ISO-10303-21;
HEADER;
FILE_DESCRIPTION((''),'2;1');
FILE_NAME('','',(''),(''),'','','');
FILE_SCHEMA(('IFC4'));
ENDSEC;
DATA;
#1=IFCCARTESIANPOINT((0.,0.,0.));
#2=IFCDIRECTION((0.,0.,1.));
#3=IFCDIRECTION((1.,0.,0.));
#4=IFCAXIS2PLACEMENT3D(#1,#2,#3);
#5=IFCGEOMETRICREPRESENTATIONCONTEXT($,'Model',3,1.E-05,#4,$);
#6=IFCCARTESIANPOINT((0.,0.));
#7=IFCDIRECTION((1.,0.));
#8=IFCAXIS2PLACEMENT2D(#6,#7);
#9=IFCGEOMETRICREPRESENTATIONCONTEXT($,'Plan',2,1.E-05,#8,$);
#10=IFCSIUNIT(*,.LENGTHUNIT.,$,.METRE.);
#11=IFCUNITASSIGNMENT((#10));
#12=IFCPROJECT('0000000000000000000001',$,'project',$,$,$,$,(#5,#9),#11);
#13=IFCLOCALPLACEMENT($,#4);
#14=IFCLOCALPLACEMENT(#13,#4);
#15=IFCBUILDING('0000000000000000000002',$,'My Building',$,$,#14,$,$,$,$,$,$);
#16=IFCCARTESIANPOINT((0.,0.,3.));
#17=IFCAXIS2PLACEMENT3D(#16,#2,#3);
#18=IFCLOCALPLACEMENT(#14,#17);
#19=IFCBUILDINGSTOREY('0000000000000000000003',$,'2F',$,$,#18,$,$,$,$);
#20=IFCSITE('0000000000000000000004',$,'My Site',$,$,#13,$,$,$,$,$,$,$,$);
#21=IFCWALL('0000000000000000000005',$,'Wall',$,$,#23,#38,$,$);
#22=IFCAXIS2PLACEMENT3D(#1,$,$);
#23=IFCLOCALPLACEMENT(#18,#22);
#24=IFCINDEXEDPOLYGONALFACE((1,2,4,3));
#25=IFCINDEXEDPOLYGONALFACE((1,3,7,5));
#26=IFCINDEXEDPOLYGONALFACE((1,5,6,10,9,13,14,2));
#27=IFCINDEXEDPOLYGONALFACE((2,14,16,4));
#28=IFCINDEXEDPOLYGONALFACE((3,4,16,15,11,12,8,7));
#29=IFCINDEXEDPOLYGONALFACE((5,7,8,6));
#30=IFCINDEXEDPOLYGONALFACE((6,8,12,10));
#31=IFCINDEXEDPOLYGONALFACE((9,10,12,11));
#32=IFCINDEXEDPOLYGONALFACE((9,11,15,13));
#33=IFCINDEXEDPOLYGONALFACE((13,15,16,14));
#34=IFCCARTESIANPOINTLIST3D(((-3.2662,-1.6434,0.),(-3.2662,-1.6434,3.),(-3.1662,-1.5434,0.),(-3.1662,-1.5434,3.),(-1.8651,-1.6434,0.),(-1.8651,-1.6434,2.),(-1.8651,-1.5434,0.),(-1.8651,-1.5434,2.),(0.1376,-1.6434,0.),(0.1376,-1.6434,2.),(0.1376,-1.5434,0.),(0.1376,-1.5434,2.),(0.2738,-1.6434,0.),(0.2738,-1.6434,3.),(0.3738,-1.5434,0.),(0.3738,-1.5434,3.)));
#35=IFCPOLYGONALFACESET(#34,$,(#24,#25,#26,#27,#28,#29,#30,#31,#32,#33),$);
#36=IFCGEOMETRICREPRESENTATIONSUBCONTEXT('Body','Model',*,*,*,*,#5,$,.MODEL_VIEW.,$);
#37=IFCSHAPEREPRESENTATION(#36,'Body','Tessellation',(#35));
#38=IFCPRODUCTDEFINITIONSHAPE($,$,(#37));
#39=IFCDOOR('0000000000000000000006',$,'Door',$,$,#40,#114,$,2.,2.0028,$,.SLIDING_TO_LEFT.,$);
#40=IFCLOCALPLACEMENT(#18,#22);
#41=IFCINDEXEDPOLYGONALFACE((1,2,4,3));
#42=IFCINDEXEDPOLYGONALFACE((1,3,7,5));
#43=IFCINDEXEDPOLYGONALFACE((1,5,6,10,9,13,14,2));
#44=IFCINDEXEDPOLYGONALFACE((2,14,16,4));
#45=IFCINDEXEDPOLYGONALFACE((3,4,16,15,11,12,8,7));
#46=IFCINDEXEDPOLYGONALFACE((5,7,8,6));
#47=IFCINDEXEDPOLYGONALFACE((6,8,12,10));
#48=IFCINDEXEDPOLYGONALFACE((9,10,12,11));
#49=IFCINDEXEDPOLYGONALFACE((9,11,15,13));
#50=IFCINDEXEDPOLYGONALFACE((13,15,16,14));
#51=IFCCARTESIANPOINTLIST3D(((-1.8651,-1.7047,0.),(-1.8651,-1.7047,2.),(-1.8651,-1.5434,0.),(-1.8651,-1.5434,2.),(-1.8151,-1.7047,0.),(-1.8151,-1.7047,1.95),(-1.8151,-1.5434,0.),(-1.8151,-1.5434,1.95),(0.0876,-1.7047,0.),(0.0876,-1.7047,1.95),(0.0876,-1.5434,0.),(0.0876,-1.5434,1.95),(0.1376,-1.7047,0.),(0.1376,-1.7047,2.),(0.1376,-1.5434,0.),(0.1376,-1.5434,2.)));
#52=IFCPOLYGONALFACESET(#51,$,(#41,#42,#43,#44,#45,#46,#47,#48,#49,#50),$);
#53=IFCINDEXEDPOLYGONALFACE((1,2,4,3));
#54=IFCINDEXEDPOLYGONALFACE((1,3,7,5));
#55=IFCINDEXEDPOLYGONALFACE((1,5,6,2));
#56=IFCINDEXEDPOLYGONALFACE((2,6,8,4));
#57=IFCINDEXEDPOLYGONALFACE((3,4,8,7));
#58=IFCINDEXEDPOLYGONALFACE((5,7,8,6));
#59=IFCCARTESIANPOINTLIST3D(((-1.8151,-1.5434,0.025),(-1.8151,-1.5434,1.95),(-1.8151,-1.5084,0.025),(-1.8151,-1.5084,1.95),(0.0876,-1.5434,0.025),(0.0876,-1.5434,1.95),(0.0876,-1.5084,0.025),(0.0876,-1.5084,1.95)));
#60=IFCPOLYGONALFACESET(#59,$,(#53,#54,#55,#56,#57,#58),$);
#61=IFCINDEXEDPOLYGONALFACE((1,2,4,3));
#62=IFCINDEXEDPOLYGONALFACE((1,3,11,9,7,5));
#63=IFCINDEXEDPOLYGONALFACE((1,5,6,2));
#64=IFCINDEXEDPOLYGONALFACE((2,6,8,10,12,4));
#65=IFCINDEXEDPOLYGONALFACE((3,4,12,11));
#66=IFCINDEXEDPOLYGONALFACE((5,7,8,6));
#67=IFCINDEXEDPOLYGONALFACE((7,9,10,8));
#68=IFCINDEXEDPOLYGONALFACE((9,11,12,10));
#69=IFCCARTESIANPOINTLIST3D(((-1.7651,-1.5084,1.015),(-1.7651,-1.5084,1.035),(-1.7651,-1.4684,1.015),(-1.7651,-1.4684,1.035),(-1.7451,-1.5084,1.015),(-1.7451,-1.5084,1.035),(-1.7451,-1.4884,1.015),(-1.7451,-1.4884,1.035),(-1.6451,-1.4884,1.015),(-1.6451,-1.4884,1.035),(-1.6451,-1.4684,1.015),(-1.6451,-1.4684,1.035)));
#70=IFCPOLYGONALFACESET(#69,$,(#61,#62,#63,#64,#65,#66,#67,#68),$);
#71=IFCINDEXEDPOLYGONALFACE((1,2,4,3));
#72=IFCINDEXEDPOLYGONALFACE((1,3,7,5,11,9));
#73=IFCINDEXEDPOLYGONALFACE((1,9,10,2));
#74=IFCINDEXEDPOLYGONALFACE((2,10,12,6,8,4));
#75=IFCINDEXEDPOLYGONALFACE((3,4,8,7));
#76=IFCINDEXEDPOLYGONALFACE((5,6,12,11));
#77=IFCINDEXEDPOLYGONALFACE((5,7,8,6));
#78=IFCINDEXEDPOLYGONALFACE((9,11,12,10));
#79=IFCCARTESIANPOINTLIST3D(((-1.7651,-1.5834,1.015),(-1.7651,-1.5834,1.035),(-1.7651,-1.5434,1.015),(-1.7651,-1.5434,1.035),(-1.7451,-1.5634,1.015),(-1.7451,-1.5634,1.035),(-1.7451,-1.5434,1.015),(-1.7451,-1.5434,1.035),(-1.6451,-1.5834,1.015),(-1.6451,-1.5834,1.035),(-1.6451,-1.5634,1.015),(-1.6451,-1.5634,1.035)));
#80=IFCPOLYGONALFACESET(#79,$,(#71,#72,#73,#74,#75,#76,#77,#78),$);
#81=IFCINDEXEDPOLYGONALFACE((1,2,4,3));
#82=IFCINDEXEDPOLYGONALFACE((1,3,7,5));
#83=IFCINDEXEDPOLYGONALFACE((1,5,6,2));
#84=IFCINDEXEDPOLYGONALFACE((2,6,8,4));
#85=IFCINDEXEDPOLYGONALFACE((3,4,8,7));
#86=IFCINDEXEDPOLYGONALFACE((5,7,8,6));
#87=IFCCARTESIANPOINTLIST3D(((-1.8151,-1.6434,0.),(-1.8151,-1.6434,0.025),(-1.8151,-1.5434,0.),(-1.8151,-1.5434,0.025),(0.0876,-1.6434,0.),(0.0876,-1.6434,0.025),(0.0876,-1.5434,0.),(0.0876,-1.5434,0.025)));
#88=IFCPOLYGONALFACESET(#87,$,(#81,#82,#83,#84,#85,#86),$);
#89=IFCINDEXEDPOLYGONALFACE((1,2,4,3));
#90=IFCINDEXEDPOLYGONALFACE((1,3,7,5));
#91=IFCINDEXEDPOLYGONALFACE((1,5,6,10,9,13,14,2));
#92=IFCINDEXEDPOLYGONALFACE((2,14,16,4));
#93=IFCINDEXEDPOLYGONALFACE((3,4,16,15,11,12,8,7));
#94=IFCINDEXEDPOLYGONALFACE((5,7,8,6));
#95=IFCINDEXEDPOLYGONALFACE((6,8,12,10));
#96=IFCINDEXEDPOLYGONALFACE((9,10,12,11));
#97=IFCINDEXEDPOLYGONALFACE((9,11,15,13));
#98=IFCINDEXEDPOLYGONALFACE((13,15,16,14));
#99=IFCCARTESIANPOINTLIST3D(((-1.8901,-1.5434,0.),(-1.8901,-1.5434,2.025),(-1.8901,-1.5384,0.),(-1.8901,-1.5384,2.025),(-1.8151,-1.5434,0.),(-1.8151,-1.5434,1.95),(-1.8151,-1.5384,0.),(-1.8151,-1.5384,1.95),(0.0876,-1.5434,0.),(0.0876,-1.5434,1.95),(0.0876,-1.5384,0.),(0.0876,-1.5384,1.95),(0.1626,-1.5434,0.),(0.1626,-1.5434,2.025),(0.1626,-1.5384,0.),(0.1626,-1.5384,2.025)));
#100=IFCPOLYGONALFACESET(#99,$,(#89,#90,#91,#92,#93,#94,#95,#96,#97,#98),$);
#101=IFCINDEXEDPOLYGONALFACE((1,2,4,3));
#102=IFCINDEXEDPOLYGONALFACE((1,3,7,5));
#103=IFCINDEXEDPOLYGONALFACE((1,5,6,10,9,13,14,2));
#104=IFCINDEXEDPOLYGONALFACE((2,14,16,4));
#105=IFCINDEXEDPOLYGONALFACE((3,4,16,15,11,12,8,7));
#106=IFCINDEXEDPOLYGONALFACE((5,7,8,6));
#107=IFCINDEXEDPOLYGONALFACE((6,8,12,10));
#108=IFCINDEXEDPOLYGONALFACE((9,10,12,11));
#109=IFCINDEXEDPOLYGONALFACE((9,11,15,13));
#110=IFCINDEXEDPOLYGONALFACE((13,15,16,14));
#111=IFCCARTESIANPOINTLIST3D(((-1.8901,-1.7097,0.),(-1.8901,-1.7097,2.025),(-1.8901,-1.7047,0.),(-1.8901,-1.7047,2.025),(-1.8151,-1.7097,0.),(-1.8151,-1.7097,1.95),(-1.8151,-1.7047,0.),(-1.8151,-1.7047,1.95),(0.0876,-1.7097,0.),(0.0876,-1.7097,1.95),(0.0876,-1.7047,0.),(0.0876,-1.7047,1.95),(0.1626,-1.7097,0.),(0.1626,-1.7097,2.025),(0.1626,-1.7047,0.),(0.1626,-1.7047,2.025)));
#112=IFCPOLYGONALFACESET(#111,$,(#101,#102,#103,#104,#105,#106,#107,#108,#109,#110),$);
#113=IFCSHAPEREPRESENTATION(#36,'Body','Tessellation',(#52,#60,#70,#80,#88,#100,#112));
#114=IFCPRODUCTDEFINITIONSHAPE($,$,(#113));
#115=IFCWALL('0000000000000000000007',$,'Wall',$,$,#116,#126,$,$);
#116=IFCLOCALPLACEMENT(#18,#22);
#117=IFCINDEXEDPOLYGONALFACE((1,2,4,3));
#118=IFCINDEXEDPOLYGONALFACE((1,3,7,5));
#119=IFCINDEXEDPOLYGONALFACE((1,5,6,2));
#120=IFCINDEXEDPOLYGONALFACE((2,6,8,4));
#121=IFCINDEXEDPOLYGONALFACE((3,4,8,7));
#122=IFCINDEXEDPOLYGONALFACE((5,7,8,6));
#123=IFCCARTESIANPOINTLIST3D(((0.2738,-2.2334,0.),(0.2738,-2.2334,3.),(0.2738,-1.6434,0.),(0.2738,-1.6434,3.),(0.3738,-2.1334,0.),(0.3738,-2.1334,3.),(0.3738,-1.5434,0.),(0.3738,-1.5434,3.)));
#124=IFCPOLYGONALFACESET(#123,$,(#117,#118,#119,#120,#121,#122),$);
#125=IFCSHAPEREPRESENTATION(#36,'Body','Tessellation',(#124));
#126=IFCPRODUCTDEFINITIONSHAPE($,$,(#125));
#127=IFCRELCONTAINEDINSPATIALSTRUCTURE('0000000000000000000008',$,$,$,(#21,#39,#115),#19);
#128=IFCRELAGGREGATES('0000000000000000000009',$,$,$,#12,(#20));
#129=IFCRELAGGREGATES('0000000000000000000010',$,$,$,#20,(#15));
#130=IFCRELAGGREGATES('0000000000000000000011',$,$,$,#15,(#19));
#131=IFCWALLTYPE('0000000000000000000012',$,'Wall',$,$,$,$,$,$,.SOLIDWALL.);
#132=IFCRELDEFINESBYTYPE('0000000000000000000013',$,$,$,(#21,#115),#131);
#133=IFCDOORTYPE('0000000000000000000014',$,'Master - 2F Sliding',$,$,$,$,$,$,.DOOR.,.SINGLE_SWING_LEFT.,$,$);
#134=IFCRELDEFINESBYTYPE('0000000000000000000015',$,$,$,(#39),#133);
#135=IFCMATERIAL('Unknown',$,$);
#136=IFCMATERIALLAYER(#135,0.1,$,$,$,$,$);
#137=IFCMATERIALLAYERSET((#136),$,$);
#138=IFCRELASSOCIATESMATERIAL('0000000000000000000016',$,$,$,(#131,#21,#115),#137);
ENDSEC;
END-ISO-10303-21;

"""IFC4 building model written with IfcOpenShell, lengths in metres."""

from ifc_helpers import new_model, entity, si_unit, frame, origin_with_axes, origin_2d_with_axis, place, context, subcontext, project, spatial, line, indexed_curve, outline, extrude, shape, source, transform, mapped, material, layer, layer_set, layer_usage, type_object, type_shapes, element, fill, save


model = new_model("IFC4")

# Units and contexts
model_context = context("Model", 3, precision=1e-05, world=origin_with_axes())
plan_context = context("Plan", 2, precision=1e-05, world=origin_2d_with_axis())
body_context_1 = subcontext(model_context, "Body", "Model", "MODEL_VIEW")
body_context_2 = subcontext(plan_context, "Body", "Plan", "PLAN_VIEW")
ifc_project = project(units=[si_unit("LENGTHUNIT", "METRE")], contexts=[model_context, plan_context])

# Site, building, storey
site_placement = place(None, origin_with_axes())
site = spatial("IfcSite", under=ifc_project, at=site_placement, Name="My Site")
building_placement = place(site_placement, origin_with_axes())
building = spatial("IfcBuilding", under=site, at=building_placement, Name="My Building")
storey_placement = place(building_placement, frame((0.0, 0.0, 3.0), z_axis=(0.0, 0.0, 1.0), x_axis=(1.0, 0.0, 0.0)))
storey = spatial("IfcBuildingStorey", under=building, at=storey_placement, Name="2F")

# Shared definitions
ifc_material = material(Name="Unknown")

# Shared definitions
ifc_layer_1 = layer(ifc_material, 0.1)
ifc_layer_set_1 = layer_set([ifc_layer_1])
wall_type = type_object("IfcWallType", Name="Wall", PredefinedType="SOLIDWALL", material=ifc_layer_set_1)

# Wall, opening, door
ifc_layer_usage_1 = layer_usage(ifc_layer_set_1, "AXIS2", "POSITIVE", 0.0)
wall_1_placement = place(storey_placement, frame((-3.2662, -1.6434, 0.0), z_axis=(0.0, 0.0, 1.0), x_axis=(1.0, 0.0, 0.0)))
wall_1 = element("IfcWall", 1, at=wall_1_placement, inside=storey, type_object=wall_type, material=ifc_layer_usage_1, Name="Wall", context=body_context_1, shape_type="SweptSolid", body=[
    extrude(outline(indexed_curve([(0.0, 0.0), (0.1, 0.1), (3.64, 0.1), (3.54, 0.0)], segments=[line(1, 2, 3, 4, 1)])), origin_with_axes(), (0.0, 0.0, 1.0), 3.0),
])
shared_shape_1 = source(origin_with_axes(), body_context_1, "Body", "SweptSolid", [
    extrude(outline(indexed_curve([(0.0, 0.0), (2.0028, 0.0), (2.0028, 2.0), (0.0, 2.0)], segments=[line(1, 2, 3, 4, 1)])), frame((0.0, -0.6, 0.0), z_axis=(0.0, -1.0, 0.0), x_axis=(1.0, 0.0, 0.0)), (0.0, 0.0, -1.0), 1.2),
])
opening_1_placement = place(wall_1_placement, frame((3.4038, 0.1, 0.0), z_axis=(0.0, 0.0, 1.0), x_axis=(-1.0, 0.0, 0.0)))
opening_1 = element("IfcOpeningElement", 2, at=opening_1_placement, cuts=wall_1, PredefinedType="OPENING", context=body_context_1, shape_type="MappedRepresentation", body=[
    mapped(shared_shape_1, transform((0.0, 0.0, 0.0), x_axis=(1.0, 0.0, 0.0), y_axis=(0.0, 1.0, 0.0), z_axis=(0.0, 0.0, 1.0), scale=1.0)),
])
door_type_1 = type_object("IfcDoorType", Name="Master - 2F Sliding", OperationType="SINGLE_SWING_LEFT", PredefinedType="DOOR")
shared_shape_2 = source(origin_with_axes(), body_context_1, "Body", "SweptSolid", [
    extrude(outline(indexed_curve([(0.0, 0.0), (0.0, 2.0), (2.0028, 2.0), (2.0028, 0.0), (1.9528, 0.0), (1.9528, 1.95), (0.05, 1.95), (0.05, 0.0)], segments=[line(1, 2, 3, 4, 5, 6, 7, 8, 1)])), frame((0.0, 0.0, 0.0), z_axis=(0.0, -1.0, 0.0), x_axis=(1.0, 0.0, 0.0)), (0.0, 0.0, -1.0), 0.1612),
    extrude(outline(indexed_curve([(0.0, 0.0), (1.9028, 0.0), (1.9028, 0.035), (0.0, 0.035)], segments=[line(1, 2, 3, 4, 1)])), frame((0.05, -0.035, 0.025), z_axis=(0.0, 0.0, 1.0), x_axis=(1.0, 0.0, 0.0)), (0.0, 0.0, 1.0), 1.925),
    extrude(outline(indexed_curve([(0.0, 0.0), (0.0, -0.04), (-0.12, -0.04), (-0.12, -0.02), (-0.02, -0.02), (-0.02, 0.0)], segments=[line(1, 2, 3, 4, 5, 6, 1)])), frame((1.9028, -0.035, 1.015), z_axis=(0.0, 0.0, 1.0), x_axis=(1.0, 0.0, 0.0)), (0.0, 0.0, 1.0), 0.02),
    extrude(outline(indexed_curve([(0.0, 0.0), (0.0, 0.04), (-0.12, 0.04), (-0.12, 0.02), (-0.02, 0.02), (-0.02, 0.0)], segments=[line(1, 2, 3, 4, 5, 6, 1)])), frame((1.9028, 0.0, 1.015), z_axis=(0.0, 0.0, 1.0), x_axis=(1.0, 0.0, 0.0)), (0.0, 0.0, 1.0), 0.02),
    extrude(outline(indexed_curve([(0.0, 0.0), (1.9028, 0.0), (1.9028, 0.1), (0.0, 0.1)], segments=[line(1, 2, 3, 4, 1)])), frame((0.05, 0.0, 0.0), z_axis=(0.0, 0.0, 1.0), x_axis=(1.0, 0.0, 0.0)), (0.0, 0.0, 1.0), 0.025),
    extrude(outline(indexed_curve([(0.0, 0.0), (0.0, 2.025), (2.0528, 2.025), (2.0528, 0.0), (1.9778, 0.0), (1.9778, 1.95), (0.075, 1.95), (0.075, 0.0)], segments=[line(1, 2, 3, 4, 5, 6, 7, 8, 1)])), frame((-0.025, -0.005, 0.0), z_axis=(0.0, -1.0, 0.0), x_axis=(1.0, 0.0, 0.0)), (0.0, 0.0, -1.0), 0.005),
    extrude(outline(indexed_curve([(0.0, 0.0), (0.0, 2.025), (2.0528, 2.025), (2.0528, 0.0), (1.9778, 0.0), (1.9778, 1.95), (0.075, 1.95), (0.075, 0.0)], segments=[line(1, 2, 3, 4, 5, 6, 7, 8, 1)])), frame((-0.025, 0.1612, 0.0), z_axis=(0.0, -1.0, 0.0), x_axis=(1.0, 0.0, 0.0)), (0.0, 0.0, -1.0), 0.005),
])
shared_shape_3 = source(origin_with_axes(), body_context_2, "Body", "Curve2D", [
    entity("IfcIndexedPolyCurve", entity("IfcCartesianPointList2D", [[0.0, 0.0], [0.05, 0.0], [0.05, 0.1612], [0.0, 0.1612]]), [entity("IfcLineIndex", [1, 2, 3, 4, 1])]),
    entity("IfcIndexedPolyCurve", entity("IfcCartesianPointList2D", [[2.0028, 0.0], [1.9528, 0.0], [1.9528, 0.1612], [2.0028, 0.1612]]), [entity("IfcLineIndex", [1, 2, 3, 4, 1])]),
    entity("IfcIndexedPolyCurve", entity("IfcCartesianPointList2D", [[-0.9014, -0.035], [1.0014, -0.035], [1.0014, 0.0], [-0.9014, 0.0]]), [entity("IfcLineIndex", [1, 2, 3, 4, 1])]),
])
type_shapes(door_type_1, [shared_shape_2, shared_shape_3])
door_1_placement = place(opening_1_placement, origin_with_axes())
door_1 = element("IfcDoor", 3, at=door_1_placement, inside=storey, type_object=door_type_1, Name="Door", OperationType="SLIDING_TO_LEFT", OverallHeight=2.0, OverallWidth=2.0028, shapes=[
    shape(body_context_1, "Body", "MappedRepresentation", [mapped(shared_shape_2, transform((0.0, 0.0, 0.0), x_axis=(1.0, 0.0, 0.0), y_axis=(0.0, 1.0, 0.0), z_axis=(0.0, 0.0, 1.0), scale=1.0))]),
    shape(body_context_2, "Body", "MappedRepresentation", [mapped(shared_shape_3, transform((0.0, 0.0, 0.0), x_axis=(1.0, 0.0, 0.0), y_axis=(0.0, 1.0, 0.0), z_axis=(0.0, 0.0, 1.0), scale=1.0))]),
])
fill(opening_1, door_1)

# Wall
ifc_layer_usage_2 = layer_usage(ifc_layer_set_1, "AXIS2", "POSITIVE", 0.0)
wall_2_placement = place(storey_placement, frame((0.2738, -1.6434, 0.0), z_axis=(0.0, 0.0, 1.0), x_axis=(0.0, -1.0, 0.0)))
element("IfcWall", 4, at=wall_2_placement, inside=storey, type_object=wall_type, material=ifc_layer_usage_2, Name="Wall", context=body_context_1, shape_type="SweptSolid", body=[
    extrude(outline(indexed_curve([(0.0, 0.0), (-0.1, 0.1), (0.49, 0.1), (0.59, 0.0)], segments=[line(1, 2, 3, 4, 1)])), origin_with_axes(), (0.0, 0.0, 1.0), 3.0),
])

save(model, "model.ifc")
